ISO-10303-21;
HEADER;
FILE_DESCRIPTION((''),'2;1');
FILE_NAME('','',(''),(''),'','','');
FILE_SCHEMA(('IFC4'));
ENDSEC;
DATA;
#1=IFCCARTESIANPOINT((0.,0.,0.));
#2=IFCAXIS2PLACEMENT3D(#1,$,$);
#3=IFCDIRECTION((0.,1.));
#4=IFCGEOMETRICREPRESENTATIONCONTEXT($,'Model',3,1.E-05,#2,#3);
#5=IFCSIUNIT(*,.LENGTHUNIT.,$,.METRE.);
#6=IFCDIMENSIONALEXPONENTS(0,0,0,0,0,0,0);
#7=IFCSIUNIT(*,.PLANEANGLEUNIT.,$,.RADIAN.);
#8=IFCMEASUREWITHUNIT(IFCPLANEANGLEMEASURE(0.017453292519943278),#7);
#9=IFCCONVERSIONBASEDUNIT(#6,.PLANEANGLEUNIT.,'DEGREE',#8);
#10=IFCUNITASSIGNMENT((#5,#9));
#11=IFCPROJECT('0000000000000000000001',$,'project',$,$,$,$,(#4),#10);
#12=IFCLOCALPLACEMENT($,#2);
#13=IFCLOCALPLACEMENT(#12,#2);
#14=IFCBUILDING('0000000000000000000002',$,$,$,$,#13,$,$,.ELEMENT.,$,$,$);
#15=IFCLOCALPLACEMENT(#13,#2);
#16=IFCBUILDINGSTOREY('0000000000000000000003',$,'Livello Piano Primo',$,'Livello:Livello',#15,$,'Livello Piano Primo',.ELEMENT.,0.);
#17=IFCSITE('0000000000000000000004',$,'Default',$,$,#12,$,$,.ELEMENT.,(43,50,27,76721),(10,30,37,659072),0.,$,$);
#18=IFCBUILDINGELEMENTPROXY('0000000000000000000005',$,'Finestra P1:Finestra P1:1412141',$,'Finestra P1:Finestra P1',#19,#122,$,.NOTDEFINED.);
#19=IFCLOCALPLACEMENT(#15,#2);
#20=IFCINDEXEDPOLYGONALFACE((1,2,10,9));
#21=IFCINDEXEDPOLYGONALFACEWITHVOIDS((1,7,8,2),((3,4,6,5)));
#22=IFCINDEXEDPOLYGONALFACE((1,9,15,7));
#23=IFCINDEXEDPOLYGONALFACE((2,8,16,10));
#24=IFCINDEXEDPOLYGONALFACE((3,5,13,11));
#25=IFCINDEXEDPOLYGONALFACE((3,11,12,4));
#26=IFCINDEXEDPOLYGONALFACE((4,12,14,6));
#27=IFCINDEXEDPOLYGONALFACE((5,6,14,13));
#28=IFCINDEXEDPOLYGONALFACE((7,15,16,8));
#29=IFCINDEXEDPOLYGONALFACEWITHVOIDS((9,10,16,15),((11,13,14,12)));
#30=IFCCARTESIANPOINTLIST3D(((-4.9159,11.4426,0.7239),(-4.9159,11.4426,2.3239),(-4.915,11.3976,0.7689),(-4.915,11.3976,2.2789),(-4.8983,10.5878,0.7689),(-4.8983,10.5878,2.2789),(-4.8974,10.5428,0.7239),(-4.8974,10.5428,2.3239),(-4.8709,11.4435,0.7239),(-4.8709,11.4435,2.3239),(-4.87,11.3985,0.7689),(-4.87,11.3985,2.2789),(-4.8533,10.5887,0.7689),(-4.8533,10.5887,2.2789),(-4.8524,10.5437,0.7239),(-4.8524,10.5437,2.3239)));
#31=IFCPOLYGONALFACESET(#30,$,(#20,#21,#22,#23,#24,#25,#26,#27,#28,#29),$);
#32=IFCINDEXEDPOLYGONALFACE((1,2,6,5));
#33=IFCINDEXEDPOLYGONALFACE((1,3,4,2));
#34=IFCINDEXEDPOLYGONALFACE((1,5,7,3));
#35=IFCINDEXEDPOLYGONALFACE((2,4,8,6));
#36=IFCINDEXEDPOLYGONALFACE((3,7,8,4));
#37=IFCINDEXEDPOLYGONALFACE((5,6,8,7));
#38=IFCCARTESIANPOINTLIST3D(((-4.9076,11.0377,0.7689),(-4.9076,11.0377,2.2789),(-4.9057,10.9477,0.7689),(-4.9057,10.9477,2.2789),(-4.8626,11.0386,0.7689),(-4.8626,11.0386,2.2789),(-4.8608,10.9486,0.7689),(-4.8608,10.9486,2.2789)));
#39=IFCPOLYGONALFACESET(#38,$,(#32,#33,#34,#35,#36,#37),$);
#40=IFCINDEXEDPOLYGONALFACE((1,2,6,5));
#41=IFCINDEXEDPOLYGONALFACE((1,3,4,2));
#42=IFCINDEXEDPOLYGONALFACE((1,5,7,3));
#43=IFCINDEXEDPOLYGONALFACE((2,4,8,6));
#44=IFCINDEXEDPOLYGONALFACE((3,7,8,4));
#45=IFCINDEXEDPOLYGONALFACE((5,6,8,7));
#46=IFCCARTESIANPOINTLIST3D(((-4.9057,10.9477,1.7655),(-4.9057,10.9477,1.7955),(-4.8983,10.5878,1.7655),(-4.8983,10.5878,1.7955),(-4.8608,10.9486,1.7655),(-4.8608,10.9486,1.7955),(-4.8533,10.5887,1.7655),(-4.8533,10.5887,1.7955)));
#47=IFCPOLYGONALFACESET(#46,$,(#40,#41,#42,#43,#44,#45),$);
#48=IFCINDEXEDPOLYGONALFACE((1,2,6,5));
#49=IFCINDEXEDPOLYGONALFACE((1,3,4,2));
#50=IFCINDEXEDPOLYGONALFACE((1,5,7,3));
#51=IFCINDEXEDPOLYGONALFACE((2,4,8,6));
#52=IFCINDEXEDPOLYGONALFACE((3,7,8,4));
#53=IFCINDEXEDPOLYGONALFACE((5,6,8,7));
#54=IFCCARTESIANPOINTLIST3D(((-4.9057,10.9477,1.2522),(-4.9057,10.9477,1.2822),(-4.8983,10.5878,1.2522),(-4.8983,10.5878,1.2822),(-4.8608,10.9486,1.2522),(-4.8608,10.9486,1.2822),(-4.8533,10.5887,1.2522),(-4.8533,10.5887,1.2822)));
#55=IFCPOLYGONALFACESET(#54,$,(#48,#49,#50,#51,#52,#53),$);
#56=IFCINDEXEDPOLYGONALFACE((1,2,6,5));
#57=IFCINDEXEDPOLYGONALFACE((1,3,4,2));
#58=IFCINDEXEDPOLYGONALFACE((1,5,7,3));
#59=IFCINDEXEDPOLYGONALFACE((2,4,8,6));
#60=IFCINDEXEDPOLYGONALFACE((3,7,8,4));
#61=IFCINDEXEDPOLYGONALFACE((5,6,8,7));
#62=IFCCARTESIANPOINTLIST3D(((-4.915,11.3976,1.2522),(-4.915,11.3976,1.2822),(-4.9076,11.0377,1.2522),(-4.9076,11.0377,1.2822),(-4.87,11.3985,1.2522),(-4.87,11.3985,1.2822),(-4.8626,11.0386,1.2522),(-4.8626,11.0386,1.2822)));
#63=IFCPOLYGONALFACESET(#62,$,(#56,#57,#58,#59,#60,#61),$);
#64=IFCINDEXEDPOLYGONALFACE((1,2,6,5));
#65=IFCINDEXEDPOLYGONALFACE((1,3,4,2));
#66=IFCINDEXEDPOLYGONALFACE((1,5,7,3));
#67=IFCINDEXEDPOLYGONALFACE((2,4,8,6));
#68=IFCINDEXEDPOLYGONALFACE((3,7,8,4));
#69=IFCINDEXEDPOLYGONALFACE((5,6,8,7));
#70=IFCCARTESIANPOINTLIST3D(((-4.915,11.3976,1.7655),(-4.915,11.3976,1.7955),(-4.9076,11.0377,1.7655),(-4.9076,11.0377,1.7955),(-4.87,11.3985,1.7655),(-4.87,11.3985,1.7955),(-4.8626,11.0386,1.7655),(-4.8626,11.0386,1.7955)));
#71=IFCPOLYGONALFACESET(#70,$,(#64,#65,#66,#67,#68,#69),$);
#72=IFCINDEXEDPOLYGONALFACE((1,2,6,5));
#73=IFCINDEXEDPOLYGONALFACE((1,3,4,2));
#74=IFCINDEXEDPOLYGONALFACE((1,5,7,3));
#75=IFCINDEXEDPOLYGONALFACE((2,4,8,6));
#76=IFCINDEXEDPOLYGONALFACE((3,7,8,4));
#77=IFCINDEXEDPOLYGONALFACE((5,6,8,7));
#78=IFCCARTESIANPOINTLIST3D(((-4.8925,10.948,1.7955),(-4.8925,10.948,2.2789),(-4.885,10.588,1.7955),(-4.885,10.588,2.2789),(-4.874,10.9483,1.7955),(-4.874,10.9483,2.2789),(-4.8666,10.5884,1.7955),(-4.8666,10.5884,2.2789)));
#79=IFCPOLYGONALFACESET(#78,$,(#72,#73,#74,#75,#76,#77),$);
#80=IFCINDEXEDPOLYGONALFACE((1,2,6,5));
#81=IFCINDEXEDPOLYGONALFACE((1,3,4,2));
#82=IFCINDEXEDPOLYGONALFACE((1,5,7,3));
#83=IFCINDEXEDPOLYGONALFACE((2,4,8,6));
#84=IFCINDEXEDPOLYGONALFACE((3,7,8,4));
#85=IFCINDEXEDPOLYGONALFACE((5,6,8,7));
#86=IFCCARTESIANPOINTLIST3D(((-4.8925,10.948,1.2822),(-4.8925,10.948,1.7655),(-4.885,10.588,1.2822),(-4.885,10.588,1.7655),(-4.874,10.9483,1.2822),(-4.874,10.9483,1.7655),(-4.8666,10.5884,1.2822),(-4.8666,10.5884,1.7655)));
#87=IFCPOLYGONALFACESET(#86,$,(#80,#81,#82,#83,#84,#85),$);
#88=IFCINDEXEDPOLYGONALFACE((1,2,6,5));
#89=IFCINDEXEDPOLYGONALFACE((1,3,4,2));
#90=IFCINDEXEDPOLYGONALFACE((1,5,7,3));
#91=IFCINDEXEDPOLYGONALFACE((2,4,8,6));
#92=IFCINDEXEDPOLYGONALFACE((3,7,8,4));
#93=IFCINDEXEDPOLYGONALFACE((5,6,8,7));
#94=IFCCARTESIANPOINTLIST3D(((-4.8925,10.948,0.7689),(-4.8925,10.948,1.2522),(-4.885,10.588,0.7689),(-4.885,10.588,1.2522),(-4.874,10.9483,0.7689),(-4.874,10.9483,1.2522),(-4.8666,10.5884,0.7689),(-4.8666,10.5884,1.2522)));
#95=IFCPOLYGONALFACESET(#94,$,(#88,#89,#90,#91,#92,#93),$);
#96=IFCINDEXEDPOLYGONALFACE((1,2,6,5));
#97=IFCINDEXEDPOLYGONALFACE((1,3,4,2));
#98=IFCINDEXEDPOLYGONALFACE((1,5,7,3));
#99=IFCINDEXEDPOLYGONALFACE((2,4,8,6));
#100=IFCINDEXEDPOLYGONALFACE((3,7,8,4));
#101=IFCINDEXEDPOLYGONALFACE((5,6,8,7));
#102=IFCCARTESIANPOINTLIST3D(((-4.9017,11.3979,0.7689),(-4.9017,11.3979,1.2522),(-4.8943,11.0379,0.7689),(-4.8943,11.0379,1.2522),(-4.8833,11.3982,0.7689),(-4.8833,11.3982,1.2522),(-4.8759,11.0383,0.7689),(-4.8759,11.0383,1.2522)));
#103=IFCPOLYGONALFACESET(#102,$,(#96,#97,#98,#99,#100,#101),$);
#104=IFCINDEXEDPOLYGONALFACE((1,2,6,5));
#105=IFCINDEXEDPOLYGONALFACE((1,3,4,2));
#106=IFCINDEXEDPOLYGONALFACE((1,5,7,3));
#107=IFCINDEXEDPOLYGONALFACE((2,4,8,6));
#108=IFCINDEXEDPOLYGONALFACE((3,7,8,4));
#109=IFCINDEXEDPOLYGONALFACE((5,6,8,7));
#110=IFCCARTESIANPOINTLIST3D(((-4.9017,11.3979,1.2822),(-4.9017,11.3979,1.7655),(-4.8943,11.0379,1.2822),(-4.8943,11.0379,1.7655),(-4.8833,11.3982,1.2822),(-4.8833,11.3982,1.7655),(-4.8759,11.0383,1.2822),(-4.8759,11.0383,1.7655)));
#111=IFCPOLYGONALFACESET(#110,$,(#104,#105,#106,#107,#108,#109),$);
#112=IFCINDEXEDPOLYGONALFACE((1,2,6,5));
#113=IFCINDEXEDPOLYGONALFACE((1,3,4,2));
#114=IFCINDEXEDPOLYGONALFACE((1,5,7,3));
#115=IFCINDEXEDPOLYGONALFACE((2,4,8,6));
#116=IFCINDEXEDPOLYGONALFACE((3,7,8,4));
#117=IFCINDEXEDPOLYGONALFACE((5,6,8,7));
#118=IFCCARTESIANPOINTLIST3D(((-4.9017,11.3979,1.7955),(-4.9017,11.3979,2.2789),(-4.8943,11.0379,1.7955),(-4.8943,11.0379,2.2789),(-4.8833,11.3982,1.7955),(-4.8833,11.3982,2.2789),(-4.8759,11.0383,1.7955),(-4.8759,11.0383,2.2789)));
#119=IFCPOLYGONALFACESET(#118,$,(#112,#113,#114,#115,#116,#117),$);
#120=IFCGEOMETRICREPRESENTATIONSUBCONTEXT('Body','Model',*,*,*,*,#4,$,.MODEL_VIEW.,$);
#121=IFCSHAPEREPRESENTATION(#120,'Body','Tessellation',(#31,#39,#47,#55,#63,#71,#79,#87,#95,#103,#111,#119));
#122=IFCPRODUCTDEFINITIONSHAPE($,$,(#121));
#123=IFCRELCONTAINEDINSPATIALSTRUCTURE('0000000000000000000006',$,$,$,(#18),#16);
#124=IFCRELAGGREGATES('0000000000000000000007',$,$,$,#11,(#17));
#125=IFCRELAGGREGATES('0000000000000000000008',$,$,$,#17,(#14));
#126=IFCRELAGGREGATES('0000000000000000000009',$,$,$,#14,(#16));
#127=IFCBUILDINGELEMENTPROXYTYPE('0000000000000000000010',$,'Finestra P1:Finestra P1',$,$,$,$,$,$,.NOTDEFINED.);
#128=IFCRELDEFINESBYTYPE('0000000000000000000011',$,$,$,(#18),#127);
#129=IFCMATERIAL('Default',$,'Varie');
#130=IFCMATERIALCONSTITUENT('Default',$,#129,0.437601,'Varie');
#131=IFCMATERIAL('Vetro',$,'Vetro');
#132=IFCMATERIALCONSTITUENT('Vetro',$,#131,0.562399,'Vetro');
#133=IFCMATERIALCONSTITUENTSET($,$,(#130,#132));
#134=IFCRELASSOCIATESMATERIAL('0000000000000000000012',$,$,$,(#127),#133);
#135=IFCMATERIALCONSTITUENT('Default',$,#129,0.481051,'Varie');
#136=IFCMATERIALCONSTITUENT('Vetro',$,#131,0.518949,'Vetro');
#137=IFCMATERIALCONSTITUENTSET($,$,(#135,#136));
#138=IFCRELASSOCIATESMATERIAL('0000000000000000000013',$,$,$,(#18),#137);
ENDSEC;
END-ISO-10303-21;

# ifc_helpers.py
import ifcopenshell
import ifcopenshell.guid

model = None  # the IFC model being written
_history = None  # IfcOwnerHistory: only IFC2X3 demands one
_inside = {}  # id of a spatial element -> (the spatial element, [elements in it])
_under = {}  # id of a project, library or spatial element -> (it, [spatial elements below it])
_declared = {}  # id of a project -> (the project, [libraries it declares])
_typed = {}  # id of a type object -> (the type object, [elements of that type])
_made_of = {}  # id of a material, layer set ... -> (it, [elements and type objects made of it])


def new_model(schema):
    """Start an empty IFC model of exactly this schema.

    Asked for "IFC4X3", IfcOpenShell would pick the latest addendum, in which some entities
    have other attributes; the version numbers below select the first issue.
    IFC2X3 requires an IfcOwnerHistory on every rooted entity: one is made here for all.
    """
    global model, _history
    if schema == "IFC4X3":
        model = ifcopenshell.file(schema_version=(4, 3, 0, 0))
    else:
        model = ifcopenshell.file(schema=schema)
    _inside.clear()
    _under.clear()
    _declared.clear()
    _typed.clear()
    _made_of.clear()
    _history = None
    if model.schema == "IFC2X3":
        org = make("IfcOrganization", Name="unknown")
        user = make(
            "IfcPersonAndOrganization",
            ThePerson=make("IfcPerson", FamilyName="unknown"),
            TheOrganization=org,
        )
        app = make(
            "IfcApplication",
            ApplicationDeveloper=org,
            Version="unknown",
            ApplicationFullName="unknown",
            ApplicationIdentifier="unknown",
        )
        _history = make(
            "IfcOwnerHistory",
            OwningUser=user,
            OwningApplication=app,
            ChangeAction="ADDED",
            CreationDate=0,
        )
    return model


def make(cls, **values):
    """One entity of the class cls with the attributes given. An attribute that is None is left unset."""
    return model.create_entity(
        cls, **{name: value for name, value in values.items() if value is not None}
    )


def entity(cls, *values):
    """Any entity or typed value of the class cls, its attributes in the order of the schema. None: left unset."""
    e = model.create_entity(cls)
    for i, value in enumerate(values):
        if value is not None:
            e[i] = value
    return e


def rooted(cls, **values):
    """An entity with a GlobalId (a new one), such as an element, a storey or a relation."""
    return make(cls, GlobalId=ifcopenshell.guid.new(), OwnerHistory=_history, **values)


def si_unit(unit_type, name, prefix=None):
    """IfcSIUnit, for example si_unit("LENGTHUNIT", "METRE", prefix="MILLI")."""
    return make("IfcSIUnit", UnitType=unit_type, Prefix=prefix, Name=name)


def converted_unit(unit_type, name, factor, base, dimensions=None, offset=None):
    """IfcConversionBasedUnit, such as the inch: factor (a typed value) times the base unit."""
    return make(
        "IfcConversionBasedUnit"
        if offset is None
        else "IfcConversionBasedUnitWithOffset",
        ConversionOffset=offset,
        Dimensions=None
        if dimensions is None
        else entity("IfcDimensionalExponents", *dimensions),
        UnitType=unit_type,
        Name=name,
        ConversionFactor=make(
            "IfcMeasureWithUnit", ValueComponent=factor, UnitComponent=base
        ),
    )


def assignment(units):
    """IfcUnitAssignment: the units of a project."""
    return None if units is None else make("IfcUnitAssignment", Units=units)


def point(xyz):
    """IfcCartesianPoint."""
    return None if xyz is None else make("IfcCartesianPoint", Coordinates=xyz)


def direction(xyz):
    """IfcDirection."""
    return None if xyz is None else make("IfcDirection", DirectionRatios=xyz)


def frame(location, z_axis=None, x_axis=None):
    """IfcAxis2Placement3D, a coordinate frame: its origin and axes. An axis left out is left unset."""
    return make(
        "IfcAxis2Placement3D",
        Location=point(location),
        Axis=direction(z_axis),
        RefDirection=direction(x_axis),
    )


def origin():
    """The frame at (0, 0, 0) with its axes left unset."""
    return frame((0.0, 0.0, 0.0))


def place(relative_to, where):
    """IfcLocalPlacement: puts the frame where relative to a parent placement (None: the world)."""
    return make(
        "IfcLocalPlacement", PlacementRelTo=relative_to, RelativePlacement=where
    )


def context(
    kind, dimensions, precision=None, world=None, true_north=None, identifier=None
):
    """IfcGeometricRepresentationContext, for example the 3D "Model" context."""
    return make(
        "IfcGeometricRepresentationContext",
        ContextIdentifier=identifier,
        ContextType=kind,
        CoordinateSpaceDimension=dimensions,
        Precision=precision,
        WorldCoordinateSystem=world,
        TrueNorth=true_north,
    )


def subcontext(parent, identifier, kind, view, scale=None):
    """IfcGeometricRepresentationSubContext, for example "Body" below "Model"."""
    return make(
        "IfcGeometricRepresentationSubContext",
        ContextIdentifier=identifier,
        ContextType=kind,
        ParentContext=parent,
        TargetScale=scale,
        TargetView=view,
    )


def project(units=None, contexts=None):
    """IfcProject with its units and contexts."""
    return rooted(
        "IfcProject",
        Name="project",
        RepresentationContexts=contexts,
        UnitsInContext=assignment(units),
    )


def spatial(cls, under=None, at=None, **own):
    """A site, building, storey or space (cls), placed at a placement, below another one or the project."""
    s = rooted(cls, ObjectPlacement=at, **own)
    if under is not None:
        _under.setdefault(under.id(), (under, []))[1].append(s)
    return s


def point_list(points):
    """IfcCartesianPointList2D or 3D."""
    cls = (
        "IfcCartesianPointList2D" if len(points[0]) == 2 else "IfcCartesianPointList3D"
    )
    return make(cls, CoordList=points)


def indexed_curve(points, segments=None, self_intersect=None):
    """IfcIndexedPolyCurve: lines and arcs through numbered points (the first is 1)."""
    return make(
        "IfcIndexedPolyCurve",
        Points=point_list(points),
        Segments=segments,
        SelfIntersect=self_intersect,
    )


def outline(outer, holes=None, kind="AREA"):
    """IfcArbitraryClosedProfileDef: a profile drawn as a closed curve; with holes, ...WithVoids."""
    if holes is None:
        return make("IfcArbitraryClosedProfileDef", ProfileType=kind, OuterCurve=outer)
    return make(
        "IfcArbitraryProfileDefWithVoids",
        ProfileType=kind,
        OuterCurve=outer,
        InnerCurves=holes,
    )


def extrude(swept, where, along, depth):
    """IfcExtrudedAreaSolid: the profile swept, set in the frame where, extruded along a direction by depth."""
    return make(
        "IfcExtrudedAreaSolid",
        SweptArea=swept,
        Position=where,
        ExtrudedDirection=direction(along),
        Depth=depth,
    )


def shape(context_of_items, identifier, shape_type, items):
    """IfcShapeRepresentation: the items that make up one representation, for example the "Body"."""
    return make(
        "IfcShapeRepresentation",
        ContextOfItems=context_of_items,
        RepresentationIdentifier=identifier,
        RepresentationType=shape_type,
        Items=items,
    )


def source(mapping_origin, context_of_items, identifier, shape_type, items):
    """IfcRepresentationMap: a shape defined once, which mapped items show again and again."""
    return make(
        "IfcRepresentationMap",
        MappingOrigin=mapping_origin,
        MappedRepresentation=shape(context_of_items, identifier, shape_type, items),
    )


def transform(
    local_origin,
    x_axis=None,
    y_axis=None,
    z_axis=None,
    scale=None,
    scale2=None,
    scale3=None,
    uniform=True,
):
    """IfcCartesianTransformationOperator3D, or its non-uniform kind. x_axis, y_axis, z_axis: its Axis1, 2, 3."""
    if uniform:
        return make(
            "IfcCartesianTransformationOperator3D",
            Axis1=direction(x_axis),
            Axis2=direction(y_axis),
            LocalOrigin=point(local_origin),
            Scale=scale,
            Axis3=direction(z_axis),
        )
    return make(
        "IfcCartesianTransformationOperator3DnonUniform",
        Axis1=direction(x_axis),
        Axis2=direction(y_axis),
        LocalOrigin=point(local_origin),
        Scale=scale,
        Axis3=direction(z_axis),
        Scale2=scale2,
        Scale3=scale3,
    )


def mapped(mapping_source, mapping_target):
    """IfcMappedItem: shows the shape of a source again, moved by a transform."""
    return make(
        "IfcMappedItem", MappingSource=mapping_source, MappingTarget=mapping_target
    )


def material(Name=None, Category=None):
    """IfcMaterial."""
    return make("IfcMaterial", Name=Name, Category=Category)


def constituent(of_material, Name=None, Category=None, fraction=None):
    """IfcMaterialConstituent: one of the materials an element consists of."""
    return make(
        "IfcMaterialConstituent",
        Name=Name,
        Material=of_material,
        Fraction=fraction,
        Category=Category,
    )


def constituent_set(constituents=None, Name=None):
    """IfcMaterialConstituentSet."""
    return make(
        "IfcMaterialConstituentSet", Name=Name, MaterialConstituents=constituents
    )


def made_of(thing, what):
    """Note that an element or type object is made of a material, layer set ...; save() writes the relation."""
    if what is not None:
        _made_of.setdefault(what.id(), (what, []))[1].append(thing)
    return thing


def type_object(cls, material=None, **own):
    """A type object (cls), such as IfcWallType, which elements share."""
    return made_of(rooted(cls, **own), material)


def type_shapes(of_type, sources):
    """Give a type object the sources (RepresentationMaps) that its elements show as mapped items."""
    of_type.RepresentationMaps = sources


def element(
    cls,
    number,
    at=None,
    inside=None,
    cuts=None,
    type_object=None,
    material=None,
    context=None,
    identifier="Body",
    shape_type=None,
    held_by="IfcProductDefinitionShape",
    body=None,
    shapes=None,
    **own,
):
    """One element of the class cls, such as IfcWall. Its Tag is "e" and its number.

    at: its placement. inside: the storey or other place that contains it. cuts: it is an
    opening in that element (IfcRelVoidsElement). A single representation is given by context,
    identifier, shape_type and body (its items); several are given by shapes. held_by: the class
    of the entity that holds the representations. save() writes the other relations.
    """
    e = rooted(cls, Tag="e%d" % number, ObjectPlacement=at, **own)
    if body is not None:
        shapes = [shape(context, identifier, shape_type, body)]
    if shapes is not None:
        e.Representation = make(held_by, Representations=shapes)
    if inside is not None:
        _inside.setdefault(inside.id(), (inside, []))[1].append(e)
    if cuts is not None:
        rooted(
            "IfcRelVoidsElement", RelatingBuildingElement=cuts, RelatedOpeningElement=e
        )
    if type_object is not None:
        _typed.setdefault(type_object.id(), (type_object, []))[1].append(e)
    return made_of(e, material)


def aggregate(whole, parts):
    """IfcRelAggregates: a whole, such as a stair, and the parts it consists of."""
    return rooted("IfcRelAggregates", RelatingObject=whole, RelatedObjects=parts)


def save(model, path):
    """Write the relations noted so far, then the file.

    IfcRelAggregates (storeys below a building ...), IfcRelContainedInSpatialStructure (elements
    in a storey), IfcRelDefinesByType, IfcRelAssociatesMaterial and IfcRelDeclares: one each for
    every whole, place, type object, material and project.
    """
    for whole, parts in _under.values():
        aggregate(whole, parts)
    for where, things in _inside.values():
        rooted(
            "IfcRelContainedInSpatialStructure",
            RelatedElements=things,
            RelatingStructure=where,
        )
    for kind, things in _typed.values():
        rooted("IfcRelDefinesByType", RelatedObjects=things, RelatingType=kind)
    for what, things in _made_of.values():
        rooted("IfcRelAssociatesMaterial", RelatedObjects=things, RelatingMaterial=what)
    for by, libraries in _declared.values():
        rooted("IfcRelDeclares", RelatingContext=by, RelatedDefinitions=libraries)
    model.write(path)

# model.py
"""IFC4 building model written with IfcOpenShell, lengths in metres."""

from ifc_helpers import new_model, entity, si_unit, converted_unit, direction, frame, origin, place, context, subcontext, project, spatial, indexed_curve, outline, extrude, source, transform, mapped, material, constituent, constituent_set, type_object, type_shapes, element, save


model = new_model("IFC4")

# Units and contexts
model_context = context("Model", 3, precision=1e-05, world=origin(), true_north=direction((0.0, 1.0)))
body_context = subcontext(model_context, "Body", "Model", "MODEL_VIEW")
ifc_project = project(units=[si_unit("LENGTHUNIT", "METRE"), converted_unit("PLANEANGLEUNIT", "DEGREE", entity("IfcPlaneAngleMeasure", 0.017453292519943278), si_unit("PLANEANGLEUNIT", "RADIAN"), dimensions=[0, 0, 0, 0, 0, 0, 0])], contexts=[model_context])

# Site, building, storey
site_placement = place(None, origin())
site = spatial("IfcSite", under=ifc_project, at=site_placement, Name="Default", CompositionType="ELEMENT", RefLatitude=(43, 50, 27, 76721), RefLongitude=(10, 30, 37, 659072), RefElevation=0.0)
building_placement = place(site_placement, origin())
building = spatial("IfcBuilding", under=site, at=building_placement, CompositionType="ELEMENT")
storey_placement = place(building_placement, origin())
storey = spatial("IfcBuildingStorey", under=building, at=storey_placement, Name="Livello Piano Primo", ObjectType="Livello:Livello", LongName="Livello Piano Primo", CompositionType="ELEMENT", Elevation=0.0)

# Building element proxy
ifc_material_1 = material(Name="Default", Category="Varie")
ifc_material_2 = material(Name="Vetro", Category="Vetro")
ifc_constituent_1 = constituent(ifc_material_1, Name="Default", Category="Varie", fraction=0.437601)
ifc_constituent_2 = constituent(ifc_material_2, Name="Vetro", Category="Vetro", fraction=0.562399)
ifc_constituent_set_1 = constituent_set(constituents=[ifc_constituent_1, ifc_constituent_2])
building_element_proxy_type_1 = type_object("IfcBuildingElementProxyType", Name="Finestra P1:Finestra P1", PredefinedType="NOTDEFINED", material=ifc_constituent_set_1)
shared_shape_1 = source(origin(), body_context, "Body", "SweptSolid", [
    extrude(outline(indexed_curve([(-0.8, -0.45), (0.8, -0.45), (0.8, 0.45), (-0.8, 0.45), (-0.8, -0.45)], self_intersect=False), holes=[indexed_curve([(0.755, -0.405), (-0.755, -0.405), (-0.755, 0.405), (0.755, 0.405), (0.755, -0.405)], self_intersect=False)]), frame((0.0, -0.0225, 0.8), z_axis=(0.0, 1.0, 0.0), x_axis=(0.0, 0.0, -1.0)), (0.0, 0.0, 1.0), 0.045),
    extrude(outline(indexed_curve([(-0.045, -0.0225), (0.045, -0.0225), (0.045, 0.0225), (-0.045, 0.0225), (-0.045, -0.0225)], self_intersect=False)), frame((0.0, 0.0, 0.045), z_axis=(0.0, 0.0, 1.0), x_axis=(-1.0, 0.0, 0.0)), (0.0, 0.0, 1.0), 1.51),
    extrude(outline(indexed_curve([(-0.18, -0.0225), (0.18, -0.0225), (0.18, 0.0225), (-0.18, 0.0225), (-0.18, -0.0225)], self_intersect=False)), frame((0.225, 0.0, 1.0417)), (0.0, 0.0, 1.0), 0.03),
    extrude(outline(indexed_curve([(-0.18, -0.0225), (0.18, -0.0225), (0.18, 0.0225), (-0.18, 0.0225), (-0.18, -0.0225)], self_intersect=False)), frame((0.225, 0.0, 0.5283)), (0.0, 0.0, 1.0), 0.03),
    extrude(outline(indexed_curve([(-0.18, -0.0225), (0.18, -0.0225), (0.18, 0.0225), (-0.18, 0.0225), (-0.18, -0.0225)], self_intersect=False)), frame((-0.225, 0.0, 0.5283)), (0.0, 0.0, 1.0), 0.03),
    extrude(outline(indexed_curve([(-0.18, -0.0225), (0.18, -0.0225), (0.18, 0.0225), (-0.18, 0.0225), (-0.18, -0.0225)], self_intersect=False)), frame((-0.225, 0.0, 1.0417)), (0.0, 0.0, 1.0), 0.03),
    extrude(outline(indexed_curve([(-0.18, -0.0092), (0.18, -0.0092), (0.18, 0.0092), (-0.18, 0.0092), (-0.18, -0.0092)], self_intersect=False)), frame((0.225, 0.0, 1.0717), z_axis=(0.0, 0.0, 1.0), x_axis=(-1.0, 0.0, 0.0)), (0.0, 0.0, 1.0), 0.4833),
    extrude(outline(indexed_curve([(-0.18, -0.0092), (0.18, -0.0092), (0.18, 0.0092), (-0.18, 0.0092), (-0.18, -0.0092)], self_intersect=False)), frame((0.225, 0.0, 0.5583), z_axis=(0.0, 0.0, 1.0), x_axis=(-1.0, 0.0, 0.0)), (0.0, 0.0, 1.0), 0.4833),
    extrude(outline(indexed_curve([(-0.18, -0.0092), (0.18, -0.0092), (0.18, 0.0092), (-0.18, 0.0092), (-0.18, -0.0092)], self_intersect=False)), frame((0.225, 0.0, 0.045), z_axis=(0.0, 0.0, 1.0), x_axis=(-1.0, 0.0, 0.0)), (0.0, 0.0, 1.0), 0.4833),
    extrude(outline(indexed_curve([(-0.18, -0.0092), (0.18, -0.0092), (0.18, 0.0092), (-0.18, 0.0092), (-0.18, -0.0092)], self_intersect=False)), frame((-0.225, 0.0, 0.045), z_axis=(0.0, 0.0, 1.0), x_axis=(-1.0, 0.0, 0.0)), (0.0, 0.0, 1.0), 0.4833),
    extrude(outline(indexed_curve([(-0.18, -0.0092), (0.18, -0.0092), (0.18, 0.0092), (-0.18, 0.0092), (-0.18, -0.0092)], self_intersect=False)), frame((-0.225, 0.0, 0.5583), z_axis=(0.0, 0.0, 1.0), x_axis=(-1.0, 0.0, 0.0)), (0.0, 0.0, 1.0), 0.4833),
    extrude(outline(indexed_curve([(-0.18, -0.0092), (0.18, -0.0092), (0.18, 0.0092), (-0.18, 0.0092), (-0.18, -0.0092)], self_intersect=False)), frame((-0.225, 0.0, 1.0717), z_axis=(0.0, 0.0, 1.0), x_axis=(-1.0, 0.0, 0.0)), (0.0, 0.0, 1.0), 0.4833),
])
type_shapes(building_element_proxy_type_1, [shared_shape_1])
ifc_constituent_3 = constituent(ifc_material_1, Name="Default", Category="Varie", fraction=0.481051)
ifc_constituent_4 = constituent(ifc_material_2, Name="Vetro", Category="Vetro", fraction=0.518949)
ifc_constituent_set_2 = constituent_set(constituents=[ifc_constituent_3, ifc_constituent_4])
proxy_1_placement = place(storey_placement, frame((-4.8842, 10.9931, 0.7239), z_axis=(0.0, 0.0, 1.0), x_axis=(0.020562, -0.999789, 0.0)))
element("IfcBuildingElementProxy", 1, at=proxy_1_placement, inside=storey, type_object=building_element_proxy_type_1, material=ifc_constituent_set_2, Name="Finestra P1:Finestra P1:1412141", ObjectType="Finestra P1:Finestra P1", PredefinedType="NOTDEFINED", context=body_context, shape_type="MappedRepresentation", body=[
    mapped(shared_shape_1, transform((0.0, 0.0, 0.0), scale=1.0)),
])

save(model, "model.ifc")
